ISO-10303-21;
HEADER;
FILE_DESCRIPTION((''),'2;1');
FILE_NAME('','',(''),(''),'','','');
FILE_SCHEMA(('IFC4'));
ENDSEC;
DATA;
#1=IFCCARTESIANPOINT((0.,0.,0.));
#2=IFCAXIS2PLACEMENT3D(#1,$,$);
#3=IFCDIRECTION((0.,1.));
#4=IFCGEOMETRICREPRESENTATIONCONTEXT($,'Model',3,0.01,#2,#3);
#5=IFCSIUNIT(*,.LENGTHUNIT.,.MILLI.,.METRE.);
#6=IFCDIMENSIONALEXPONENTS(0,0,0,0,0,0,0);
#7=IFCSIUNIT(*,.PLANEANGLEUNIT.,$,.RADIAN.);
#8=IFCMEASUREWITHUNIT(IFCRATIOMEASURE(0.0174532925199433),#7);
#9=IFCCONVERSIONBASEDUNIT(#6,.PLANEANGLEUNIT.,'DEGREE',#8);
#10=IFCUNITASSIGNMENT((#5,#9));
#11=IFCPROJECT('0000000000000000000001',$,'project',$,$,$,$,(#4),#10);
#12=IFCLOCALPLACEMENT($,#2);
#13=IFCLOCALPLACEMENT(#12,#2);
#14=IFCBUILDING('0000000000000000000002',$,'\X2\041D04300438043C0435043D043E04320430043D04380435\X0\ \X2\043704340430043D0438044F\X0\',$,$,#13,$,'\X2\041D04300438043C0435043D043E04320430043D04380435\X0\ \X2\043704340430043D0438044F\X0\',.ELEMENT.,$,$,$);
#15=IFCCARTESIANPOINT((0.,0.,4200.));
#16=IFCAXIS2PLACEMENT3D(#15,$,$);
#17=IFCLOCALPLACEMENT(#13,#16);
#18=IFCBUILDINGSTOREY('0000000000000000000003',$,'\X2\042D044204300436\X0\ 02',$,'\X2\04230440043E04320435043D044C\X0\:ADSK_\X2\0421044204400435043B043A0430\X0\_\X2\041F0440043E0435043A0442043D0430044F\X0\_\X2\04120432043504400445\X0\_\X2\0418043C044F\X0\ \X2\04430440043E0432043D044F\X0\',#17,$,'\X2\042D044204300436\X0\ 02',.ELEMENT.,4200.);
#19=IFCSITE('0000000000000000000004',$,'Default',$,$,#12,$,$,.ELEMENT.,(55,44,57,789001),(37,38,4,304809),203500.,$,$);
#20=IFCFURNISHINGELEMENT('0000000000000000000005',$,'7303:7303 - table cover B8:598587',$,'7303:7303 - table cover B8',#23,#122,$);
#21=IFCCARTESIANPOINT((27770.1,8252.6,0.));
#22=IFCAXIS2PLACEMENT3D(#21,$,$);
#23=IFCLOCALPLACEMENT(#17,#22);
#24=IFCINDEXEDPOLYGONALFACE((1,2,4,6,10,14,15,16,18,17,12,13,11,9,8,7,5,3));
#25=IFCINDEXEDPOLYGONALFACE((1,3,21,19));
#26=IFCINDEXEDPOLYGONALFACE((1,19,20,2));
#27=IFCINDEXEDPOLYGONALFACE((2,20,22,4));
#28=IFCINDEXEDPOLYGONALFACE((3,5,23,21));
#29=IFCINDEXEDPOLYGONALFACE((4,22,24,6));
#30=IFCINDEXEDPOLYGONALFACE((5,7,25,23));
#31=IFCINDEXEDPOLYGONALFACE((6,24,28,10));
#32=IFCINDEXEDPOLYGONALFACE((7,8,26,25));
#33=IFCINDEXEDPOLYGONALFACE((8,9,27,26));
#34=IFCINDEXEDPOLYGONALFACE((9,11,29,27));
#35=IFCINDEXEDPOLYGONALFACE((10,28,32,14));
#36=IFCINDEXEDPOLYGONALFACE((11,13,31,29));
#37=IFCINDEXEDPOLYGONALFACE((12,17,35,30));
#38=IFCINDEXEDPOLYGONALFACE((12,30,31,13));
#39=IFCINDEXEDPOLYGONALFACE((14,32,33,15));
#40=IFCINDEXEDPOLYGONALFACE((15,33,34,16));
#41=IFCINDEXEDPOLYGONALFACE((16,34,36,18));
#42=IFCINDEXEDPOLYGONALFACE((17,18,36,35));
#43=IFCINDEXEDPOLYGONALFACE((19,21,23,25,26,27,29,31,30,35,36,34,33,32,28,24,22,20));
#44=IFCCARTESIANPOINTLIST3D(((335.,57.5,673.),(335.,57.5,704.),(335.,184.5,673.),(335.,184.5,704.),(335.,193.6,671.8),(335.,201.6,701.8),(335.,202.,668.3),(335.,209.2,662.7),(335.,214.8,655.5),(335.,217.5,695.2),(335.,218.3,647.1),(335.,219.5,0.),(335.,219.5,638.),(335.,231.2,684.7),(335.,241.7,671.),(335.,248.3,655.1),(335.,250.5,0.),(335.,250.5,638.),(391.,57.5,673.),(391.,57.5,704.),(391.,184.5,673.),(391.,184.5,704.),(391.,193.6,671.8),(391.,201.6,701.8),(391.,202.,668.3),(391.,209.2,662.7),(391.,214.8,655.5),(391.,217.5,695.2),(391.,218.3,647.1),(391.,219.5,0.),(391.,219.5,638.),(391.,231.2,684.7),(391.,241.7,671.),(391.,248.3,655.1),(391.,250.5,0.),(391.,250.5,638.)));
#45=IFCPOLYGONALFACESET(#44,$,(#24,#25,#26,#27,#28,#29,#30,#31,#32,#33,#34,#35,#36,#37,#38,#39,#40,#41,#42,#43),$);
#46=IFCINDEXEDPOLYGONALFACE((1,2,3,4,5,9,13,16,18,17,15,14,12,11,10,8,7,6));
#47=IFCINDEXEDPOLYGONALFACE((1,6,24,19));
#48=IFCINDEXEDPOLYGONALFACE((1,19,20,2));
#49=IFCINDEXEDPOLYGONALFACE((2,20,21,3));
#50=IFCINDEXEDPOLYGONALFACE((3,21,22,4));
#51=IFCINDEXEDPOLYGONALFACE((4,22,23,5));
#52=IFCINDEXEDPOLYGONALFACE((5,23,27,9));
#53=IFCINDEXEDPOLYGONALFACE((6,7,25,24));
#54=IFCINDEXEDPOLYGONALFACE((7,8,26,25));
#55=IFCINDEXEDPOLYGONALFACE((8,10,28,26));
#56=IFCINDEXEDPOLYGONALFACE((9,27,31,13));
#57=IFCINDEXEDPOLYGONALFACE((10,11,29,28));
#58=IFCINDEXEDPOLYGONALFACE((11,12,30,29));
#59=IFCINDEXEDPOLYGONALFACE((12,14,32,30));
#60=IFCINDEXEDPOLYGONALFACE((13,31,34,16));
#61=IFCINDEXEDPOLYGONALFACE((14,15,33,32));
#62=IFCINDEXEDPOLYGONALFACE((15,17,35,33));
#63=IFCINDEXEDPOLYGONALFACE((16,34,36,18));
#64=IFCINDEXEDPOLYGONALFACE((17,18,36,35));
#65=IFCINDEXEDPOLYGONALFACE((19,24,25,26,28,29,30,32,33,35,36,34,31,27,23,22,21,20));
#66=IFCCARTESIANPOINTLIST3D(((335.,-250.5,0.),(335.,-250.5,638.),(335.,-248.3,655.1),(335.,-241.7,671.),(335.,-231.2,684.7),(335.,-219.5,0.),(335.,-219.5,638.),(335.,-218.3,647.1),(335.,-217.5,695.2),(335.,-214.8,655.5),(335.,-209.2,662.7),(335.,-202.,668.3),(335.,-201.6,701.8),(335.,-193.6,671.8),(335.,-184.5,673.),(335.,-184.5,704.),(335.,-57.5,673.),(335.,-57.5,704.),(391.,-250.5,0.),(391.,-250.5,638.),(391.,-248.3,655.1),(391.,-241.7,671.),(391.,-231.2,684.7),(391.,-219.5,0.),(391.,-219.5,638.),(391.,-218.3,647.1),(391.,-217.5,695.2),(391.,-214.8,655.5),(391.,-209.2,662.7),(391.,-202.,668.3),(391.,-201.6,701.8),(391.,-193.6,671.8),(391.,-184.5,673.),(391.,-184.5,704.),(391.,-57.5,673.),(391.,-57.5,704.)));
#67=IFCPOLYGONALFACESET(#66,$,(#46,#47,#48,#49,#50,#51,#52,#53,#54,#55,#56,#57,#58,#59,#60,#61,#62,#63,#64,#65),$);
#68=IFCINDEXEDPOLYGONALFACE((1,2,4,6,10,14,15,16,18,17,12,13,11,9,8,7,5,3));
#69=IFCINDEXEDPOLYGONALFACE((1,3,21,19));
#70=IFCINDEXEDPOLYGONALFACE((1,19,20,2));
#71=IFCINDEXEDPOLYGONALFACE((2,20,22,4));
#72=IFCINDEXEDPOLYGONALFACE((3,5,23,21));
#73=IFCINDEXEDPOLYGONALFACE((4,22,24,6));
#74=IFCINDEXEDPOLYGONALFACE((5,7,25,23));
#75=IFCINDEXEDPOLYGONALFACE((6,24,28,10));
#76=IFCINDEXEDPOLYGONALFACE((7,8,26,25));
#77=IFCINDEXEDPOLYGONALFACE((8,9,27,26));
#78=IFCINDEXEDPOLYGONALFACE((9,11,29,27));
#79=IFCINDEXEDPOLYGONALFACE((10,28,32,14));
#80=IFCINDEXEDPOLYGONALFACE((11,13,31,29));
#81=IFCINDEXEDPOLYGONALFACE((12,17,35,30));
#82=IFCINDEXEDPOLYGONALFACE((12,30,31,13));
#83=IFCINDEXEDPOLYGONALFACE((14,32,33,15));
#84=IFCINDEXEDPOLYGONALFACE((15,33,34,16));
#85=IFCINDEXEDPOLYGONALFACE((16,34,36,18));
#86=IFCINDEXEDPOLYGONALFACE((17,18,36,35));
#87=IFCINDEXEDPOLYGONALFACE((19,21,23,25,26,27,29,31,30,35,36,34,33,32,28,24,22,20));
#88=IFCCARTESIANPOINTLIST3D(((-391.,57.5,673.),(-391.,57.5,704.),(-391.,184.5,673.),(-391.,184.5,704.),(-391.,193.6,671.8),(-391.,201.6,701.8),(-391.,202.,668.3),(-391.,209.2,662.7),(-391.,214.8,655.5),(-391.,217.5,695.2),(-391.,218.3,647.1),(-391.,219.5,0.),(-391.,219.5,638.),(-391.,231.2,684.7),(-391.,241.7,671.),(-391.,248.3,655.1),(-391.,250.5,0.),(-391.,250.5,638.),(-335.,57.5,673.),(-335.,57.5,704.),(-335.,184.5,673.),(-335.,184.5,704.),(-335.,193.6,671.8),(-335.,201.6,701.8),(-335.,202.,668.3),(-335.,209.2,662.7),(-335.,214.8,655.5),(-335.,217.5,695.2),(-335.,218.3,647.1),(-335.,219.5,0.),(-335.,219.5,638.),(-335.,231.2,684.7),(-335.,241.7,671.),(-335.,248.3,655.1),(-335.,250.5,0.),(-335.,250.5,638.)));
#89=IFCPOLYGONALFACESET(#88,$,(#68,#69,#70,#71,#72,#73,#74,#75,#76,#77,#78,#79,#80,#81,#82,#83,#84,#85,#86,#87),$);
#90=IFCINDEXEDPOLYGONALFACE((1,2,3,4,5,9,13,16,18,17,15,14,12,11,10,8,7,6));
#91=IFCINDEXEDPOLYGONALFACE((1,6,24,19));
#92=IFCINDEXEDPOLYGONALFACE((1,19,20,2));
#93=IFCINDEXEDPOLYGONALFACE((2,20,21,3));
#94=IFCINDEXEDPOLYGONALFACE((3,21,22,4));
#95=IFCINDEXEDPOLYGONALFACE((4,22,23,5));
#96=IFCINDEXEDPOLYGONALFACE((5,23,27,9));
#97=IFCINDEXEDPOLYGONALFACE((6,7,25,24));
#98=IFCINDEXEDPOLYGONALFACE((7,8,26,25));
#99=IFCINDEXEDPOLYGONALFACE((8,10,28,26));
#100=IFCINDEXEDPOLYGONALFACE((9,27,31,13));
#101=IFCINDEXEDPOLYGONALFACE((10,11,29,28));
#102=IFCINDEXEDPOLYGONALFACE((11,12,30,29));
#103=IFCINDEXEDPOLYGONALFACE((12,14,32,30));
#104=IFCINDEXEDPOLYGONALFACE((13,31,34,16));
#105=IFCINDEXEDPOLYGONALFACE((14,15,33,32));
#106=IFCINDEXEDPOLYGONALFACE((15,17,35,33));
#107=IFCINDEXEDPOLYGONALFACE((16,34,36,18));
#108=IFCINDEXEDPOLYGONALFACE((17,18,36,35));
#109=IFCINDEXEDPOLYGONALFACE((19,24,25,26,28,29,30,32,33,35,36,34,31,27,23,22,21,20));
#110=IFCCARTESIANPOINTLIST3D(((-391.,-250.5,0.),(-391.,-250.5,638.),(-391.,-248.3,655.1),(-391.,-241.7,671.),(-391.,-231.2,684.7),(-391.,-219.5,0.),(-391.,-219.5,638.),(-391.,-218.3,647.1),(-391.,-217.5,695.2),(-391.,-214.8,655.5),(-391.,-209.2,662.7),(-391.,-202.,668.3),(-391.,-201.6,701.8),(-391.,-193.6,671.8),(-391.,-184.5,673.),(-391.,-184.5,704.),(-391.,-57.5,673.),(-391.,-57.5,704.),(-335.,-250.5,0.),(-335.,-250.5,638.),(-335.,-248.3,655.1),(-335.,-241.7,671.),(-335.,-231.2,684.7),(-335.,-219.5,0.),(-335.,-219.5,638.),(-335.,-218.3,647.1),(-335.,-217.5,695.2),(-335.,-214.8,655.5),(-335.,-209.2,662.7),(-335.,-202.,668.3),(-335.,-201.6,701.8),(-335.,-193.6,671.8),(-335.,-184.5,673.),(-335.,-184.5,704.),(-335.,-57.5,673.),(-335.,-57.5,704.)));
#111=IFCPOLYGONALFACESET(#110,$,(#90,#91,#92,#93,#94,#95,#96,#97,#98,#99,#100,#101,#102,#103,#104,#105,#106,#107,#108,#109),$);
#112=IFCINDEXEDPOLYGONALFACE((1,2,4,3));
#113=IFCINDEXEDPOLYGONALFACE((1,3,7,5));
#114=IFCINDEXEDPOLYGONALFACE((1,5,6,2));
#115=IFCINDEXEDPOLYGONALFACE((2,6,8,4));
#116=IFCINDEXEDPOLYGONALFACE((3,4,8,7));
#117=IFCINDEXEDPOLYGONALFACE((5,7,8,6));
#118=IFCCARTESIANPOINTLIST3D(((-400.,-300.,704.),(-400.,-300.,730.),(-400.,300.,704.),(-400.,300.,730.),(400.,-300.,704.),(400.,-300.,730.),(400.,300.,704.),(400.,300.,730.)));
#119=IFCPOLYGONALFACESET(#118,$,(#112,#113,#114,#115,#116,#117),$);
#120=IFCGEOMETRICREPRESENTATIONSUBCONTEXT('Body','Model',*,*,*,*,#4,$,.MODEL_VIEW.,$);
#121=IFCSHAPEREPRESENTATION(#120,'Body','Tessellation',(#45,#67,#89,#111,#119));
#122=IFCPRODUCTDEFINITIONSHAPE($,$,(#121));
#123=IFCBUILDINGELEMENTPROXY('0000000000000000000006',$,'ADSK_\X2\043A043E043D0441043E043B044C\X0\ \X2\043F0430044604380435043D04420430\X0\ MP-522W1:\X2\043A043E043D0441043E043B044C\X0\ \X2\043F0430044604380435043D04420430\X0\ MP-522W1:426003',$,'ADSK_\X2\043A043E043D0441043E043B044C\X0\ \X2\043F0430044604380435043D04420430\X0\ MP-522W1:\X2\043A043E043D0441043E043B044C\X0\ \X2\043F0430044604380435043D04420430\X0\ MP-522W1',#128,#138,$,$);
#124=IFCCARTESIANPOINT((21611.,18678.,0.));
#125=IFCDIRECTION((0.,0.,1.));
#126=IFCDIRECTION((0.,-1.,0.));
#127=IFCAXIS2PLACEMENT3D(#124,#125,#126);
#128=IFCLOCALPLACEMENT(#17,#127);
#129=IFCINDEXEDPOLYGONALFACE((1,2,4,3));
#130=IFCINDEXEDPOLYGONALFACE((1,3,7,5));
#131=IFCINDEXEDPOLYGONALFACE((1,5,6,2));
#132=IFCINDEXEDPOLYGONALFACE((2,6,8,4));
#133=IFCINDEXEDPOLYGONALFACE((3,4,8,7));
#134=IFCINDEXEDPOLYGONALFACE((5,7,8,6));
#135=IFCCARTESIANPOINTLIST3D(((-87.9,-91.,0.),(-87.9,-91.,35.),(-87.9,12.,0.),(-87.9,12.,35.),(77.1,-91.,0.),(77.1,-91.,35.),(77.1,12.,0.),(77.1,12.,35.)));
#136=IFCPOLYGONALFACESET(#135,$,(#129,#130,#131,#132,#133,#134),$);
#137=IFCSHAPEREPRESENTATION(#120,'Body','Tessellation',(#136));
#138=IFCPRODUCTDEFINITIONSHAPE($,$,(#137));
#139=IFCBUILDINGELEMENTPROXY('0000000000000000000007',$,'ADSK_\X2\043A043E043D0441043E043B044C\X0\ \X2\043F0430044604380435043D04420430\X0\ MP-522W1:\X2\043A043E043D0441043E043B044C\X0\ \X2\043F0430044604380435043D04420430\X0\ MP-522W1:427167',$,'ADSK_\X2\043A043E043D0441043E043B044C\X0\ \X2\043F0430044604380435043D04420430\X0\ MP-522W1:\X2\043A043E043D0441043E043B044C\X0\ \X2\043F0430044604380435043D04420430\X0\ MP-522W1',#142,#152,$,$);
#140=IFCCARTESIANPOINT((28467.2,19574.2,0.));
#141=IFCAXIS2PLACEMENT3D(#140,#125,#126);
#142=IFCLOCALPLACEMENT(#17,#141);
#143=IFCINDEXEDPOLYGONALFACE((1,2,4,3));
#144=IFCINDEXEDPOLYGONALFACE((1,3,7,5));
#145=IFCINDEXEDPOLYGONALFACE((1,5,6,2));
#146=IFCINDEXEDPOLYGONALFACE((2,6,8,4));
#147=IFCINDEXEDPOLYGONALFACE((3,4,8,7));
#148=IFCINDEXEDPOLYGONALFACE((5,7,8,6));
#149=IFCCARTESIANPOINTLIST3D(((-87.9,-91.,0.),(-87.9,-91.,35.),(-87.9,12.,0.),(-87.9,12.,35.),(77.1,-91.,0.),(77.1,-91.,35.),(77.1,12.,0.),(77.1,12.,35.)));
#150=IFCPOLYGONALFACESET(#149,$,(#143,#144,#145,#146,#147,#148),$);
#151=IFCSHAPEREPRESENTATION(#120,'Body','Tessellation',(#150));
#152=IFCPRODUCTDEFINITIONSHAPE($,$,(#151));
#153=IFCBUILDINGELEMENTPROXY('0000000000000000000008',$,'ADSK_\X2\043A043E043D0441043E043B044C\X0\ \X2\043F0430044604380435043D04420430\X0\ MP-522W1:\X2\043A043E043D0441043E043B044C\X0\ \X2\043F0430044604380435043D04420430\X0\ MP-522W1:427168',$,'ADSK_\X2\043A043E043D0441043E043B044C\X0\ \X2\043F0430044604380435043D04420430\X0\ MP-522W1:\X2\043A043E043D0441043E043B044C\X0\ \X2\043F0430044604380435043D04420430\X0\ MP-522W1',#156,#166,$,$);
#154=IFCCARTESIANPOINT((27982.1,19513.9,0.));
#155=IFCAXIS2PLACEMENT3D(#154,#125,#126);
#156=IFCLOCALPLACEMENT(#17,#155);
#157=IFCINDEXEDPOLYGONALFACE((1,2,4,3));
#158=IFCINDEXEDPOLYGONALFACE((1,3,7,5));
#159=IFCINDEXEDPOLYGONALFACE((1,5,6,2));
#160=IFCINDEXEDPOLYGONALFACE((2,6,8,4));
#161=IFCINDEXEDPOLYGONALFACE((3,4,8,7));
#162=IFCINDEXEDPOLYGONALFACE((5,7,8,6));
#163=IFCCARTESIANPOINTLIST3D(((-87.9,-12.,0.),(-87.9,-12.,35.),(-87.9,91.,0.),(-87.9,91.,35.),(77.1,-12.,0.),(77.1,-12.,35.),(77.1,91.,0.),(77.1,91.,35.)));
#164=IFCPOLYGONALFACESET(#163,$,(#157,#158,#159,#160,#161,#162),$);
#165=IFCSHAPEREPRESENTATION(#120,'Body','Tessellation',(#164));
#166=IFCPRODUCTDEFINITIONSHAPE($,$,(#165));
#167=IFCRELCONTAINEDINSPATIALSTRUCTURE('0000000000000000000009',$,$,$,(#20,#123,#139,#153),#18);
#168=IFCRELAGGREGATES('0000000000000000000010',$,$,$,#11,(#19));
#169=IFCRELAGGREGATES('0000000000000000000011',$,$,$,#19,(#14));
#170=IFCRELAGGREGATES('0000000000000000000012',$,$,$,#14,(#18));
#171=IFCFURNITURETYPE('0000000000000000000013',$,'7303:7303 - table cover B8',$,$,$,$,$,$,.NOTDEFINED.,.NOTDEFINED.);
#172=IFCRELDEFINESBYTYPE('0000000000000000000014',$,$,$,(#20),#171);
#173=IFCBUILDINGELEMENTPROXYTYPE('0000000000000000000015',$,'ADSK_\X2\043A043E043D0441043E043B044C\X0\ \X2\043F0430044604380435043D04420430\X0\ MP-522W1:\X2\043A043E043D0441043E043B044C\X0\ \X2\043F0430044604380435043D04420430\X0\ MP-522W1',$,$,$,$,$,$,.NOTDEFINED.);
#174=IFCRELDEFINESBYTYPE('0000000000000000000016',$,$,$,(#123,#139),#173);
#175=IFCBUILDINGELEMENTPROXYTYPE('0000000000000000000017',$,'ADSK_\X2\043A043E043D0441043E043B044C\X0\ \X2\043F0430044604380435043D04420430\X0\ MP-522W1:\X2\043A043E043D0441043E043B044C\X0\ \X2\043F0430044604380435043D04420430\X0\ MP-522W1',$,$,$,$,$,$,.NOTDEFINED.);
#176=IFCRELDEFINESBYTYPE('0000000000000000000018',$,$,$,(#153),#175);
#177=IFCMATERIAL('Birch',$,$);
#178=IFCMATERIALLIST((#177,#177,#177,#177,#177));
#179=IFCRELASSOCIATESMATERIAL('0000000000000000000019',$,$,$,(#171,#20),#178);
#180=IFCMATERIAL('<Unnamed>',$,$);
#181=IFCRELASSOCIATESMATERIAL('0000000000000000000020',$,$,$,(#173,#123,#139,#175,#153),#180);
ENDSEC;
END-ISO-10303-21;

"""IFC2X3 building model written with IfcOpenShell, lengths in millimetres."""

from ifc_helpers import new_model, entity, si_unit, converted_unit, direction, frame, frame_2d, origin, origin_2d_with_axis, place, context, subcontext, project, spatial, polyline, circle_curve, parameter, trimmed, segment, composite_curve, rectangle, outline, extrude, source, transform, mapped, material, material_list, type_object, type_shapes, element, save


model = new_model("IFC2X3")

# Units and contexts
model_context = context("Model", 3, precision=0.01, world=origin(), true_north=direction((0.0, 1.0)))
body_context = subcontext(model_context, "Body", "Model", "MODEL_VIEW")
ifc_project = project(units=[si_unit("LENGTHUNIT", "METRE", prefix="MILLI"), converted_unit("PLANEANGLEUNIT", "DEGREE", entity("IfcRatioMeasure", 0.0174532925199433), si_unit("PLANEANGLEUNIT", "RADIAN"), dimensions=[0, 0, 0, 0, 0, 0, 0])], contexts=[model_context])

# Site, building, storey
site_placement = place(None, origin())
site = spatial("IfcSite", under=ifc_project, at=site_placement, Name="Default", CompositionType="ELEMENT", RefLatitude=(55, 44, 57, 789001), RefLongitude=(37, 38, 4, 304809), RefElevation=203500.0)
building_placement = place(site_placement, origin())
building = spatial("IfcBuilding", under=site, at=building_placement, Name="Наименование здания", LongName="Наименование здания", CompositionType="ELEMENT")
storey_placement = place(building_placement, frame((0.0, 0.0, 4200.0)))
storey = spatial("IfcBuildingStorey", under=building, at=storey_placement, Name="Этаж 02", ObjectType="Уровень:ADSK_Стрелка_Проектная_Вверх_Имя уровня", LongName="Этаж 02", CompositionType="ELEMENT", Elevation=4200.0)

# Furnishing element
ifc_material_1 = material(Name="Birch")
ifc_material_list_1 = material_list([ifc_material_1, ifc_material_1, ifc_material_1, ifc_material_1, ifc_material_1])
furniture_type_1 = type_object("IfcFurnitureType", Name="7303:7303 - table cover B8", material=ifc_material_list_1)
shared_shape_1 = source(origin(), body_context, "Body", "SweptSolid", [
    extrude(outline(composite_curve([segment(polyline([(-200.2, -120.5), (-169.2, -120.5)]), True, "CONTINUOUS"), segment(polyline([(-169.2, -120.5), (-169.2, 6.5)]), True, "CONTINUOUS"), segment(trimmed(circle_curve(frame_2d((-134.2, 6.5), x_axis=(0.0, -1.0)), 35.0), [parameter(180.0)], [parameter(270.0)], True, "PARAMETER"), False, "CONTINUOUS"), segment(polyline([(-134.2, 41.5), (503.8, 41.5)]), True, "CONTINUOUS"), segment(polyline([(503.8, 41.5), (503.8, 72.5)]), True, "CONTINUOUS"), segment(polyline([(503.8, 72.5), (-134.2, 72.5)]), True, "CONTINUOUS"), segment(trimmed(circle_curve(frame_2d((-134.2, 6.5), x_axis=(0.0, -1.0)), 66.0), [parameter(180.0)], [parameter(270.0)], True, "PARAMETER"), True, "CONTINUOUS"), segment(polyline([(-200.2, 6.5), (-200.2, -120.5)]), True, "CONTINUOUS")], self_intersect=False)), frame((335.0, 178.0, 503.8), z_axis=(1.0, 0.0, 0.0), x_axis=(0.0, 0.0, -1.0)), (0.0, 0.0, 1.0), 56.0),
    extrude(outline(composite_curve([segment(polyline([(-120.5, -200.2), (6.5, -200.2)]), True, "CONTINUOUS"), segment(trimmed(circle_curve(frame_2d((6.5, -134.2), x_axis=(-1.0, 0.0)), 66.0), [parameter(90.0)], [parameter(180.0)], True, "PARAMETER"), True, "CONTINUOUS"), segment(polyline([(72.5, -134.2), (72.5, 503.8)]), True, "CONTINUOUS"), segment(polyline([(72.5, 503.8), (41.5, 503.8)]), True, "CONTINUOUS"), segment(polyline([(41.5, 503.8), (41.5, -134.2)]), True, "CONTINUOUS"), segment(trimmed(circle_curve(frame_2d((6.5, -134.2), x_axis=(-1.0, 0.0)), 35.0), [parameter(90.0)], [parameter(180.0)], True, "PARAMETER"), False, "CONTINUOUS"), segment(polyline([(6.5, -169.2), (-120.5, -169.2)]), True, "CONTINUOUS"), segment(polyline([(-120.5, -169.2), (-120.5, -200.2)]), True, "CONTINUOUS")], self_intersect=False)), frame((335.0, -178.0, 503.8), z_axis=(1.0, 0.0, 0.0), x_axis=(0.0, -1.0, 0.0)), (0.0, 0.0, 1.0), 56.0),
    extrude(outline(composite_curve([segment(polyline([(-200.2, -120.5), (-169.2, -120.5)]), True, "CONTINUOUS"), segment(polyline([(-169.2, -120.5), (-169.2, 6.5)]), True, "CONTINUOUS"), segment(trimmed(circle_curve(frame_2d((-134.2, 6.5), x_axis=(0.0, -1.0)), 35.0), [parameter(180.0)], [parameter(270.0)], True, "PARAMETER"), False, "CONTINUOUS"), segment(polyline([(-134.2, 41.5), (503.8, 41.5)]), True, "CONTINUOUS"), segment(polyline([(503.8, 41.5), (503.8, 72.5)]), True, "CONTINUOUS"), segment(polyline([(503.8, 72.5), (-134.2, 72.5)]), True, "CONTINUOUS"), segment(trimmed(circle_curve(frame_2d((-134.2, 6.5), x_axis=(0.0, -1.0)), 66.0), [parameter(180.0)], [parameter(270.0)], True, "PARAMETER"), True, "CONTINUOUS"), segment(polyline([(-200.2, 6.5), (-200.2, -120.5)]), True, "CONTINUOUS")], self_intersect=False)), frame((-391.0, 178.0, 503.8), z_axis=(1.0, 0.0, 0.0), x_axis=(0.0, 0.0, -1.0)), (0.0, 0.0, 1.0), 56.0),
    extrude(outline(composite_curve([segment(polyline([(-120.5, -200.2), (6.5, -200.2)]), True, "CONTINUOUS"), segment(trimmed(circle_curve(frame_2d((6.5, -134.2), x_axis=(-1.0, 0.0)), 66.0), [parameter(90.0)], [parameter(180.0)], True, "PARAMETER"), True, "CONTINUOUS"), segment(polyline([(72.5, -134.2), (72.5, 503.8)]), True, "CONTINUOUS"), segment(polyline([(72.5, 503.8), (41.5, 503.8)]), True, "CONTINUOUS"), segment(polyline([(41.5, 503.8), (41.5, -134.2)]), True, "CONTINUOUS"), segment(trimmed(circle_curve(frame_2d((6.5, -134.2), x_axis=(-1.0, 0.0)), 35.0), [parameter(90.0)], [parameter(180.0)], True, "PARAMETER"), False, "CONTINUOUS"), segment(polyline([(6.5, -169.2), (-120.5, -169.2)]), True, "CONTINUOUS"), segment(polyline([(-120.5, -169.2), (-120.5, -200.2)]), True, "CONTINUOUS")], self_intersect=False)), frame((-391.0, -178.0, 503.8), z_axis=(1.0, 0.0, 0.0), x_axis=(0.0, -1.0, 0.0)), (0.0, 0.0, 1.0), 56.0),
    extrude(rectangle(XDim=800.0, YDim=600.0, at=origin_2d_with_axis()), frame((0.0, 0.0, 704.0), z_axis=(0.0, 0.0, 1.0), x_axis=(-1.0, 0.0, 0.0)), (0.0, 0.0, 1.0), 26.0),
])
type_shapes(furniture_type_1, [shared_shape_1])
furnishing_1_placement = place(storey_placement, frame((27770.1, 8252.6, 0.0)))
element("IfcFurnishingElement", 1, at=furnishing_1_placement, inside=storey, type_object=furniture_type_1, material=ifc_material_list_1, Name="7303:7303 - table cover B8:598587", ObjectType="7303:7303 - table cover B8", context=body_context, shape_type="MappedRepresentation", body=[
    mapped(shared_shape_1, transform((0.0, 0.0, 0.0), scale=1.0)),
])

# Building element proxies
ifc_material_2 = material(Name="<Unnamed>")
building_element_proxy_type_1 = type_object("IfcBuildingElementProxyType", Name="ADSK_консоль пациента MP-522W1:консоль пациента MP-522W1", PredefinedType="NOTDEFINED", material=ifc_material_2)
shared_shape_2 = source(origin(), body_context, "Body", "SweptSolid", [
    extrude(rectangle(XDim=165.0, YDim=103.0, at=origin_2d_with_axis()), frame((-5.4, -39.5, 0.0), z_axis=(0.0, 0.0, 1.0), x_axis=(-1.0, 0.0, 0.0)), (0.0, 0.0, 1.0), 35.0),
])
type_shapes(building_element_proxy_type_1, [shared_shape_2])
for number, where, z_axis, x_axis, name in (
    (2, (21611.0, 18678.0, 0.0), (0.0, 0.0, 1.0), (0.0, -1.0, 0.0), "ADSK_консоль пациента MP-522W1:консоль пациента MP-522W1:426003"),
    (3, (28467.2, 19574.2, 0.0), (0.0, 0.0, 1.0), (0.0, -1.0, 0.0), "ADSK_консоль пациента MP-522W1:консоль пациента MP-522W1:427167"),
):
    element("IfcBuildingElementProxy", number, at=place(storey_placement, frame(where, z_axis=z_axis, x_axis=x_axis)), inside=storey, type_object=building_element_proxy_type_1, material=ifc_material_2, Name=name, ObjectType="ADSK_консоль пациента MP-522W1:консоль пациента MP-522W1", context=body_context, shape_type="MappedRepresentation", body=[
        mapped(shared_shape_2, transform((0.0, 0.0, 0.0), scale=1.0)),
    ])
building_element_proxy_type_2 = type_object("IfcBuildingElementProxyType", Name="ADSK_консоль пациента MP-522W1:консоль пациента MP-522W1", PredefinedType="NOTDEFINED", material=ifc_material_2)
shared_shape_3 = source(origin(), body_context, "Body", "SweptSolid", [
    extrude(rectangle(XDim=103.0, YDim=165.0, at=origin_2d_with_axis()), frame((-5.4, 39.5, 0.0), z_axis=(0.0, 0.0, 1.0), x_axis=(0.0, 1.0, 0.0)), (0.0, 0.0, 1.0), 35.0),
])
type_shapes(building_element_proxy_type_2, [shared_shape_3])
proxy_1_placement = place(storey_placement, frame((27982.1, 19513.9, 0.0), z_axis=(0.0, 0.0, 1.0), x_axis=(0.0, -1.0, 0.0)))
element("IfcBuildingElementProxy", 4, at=proxy_1_placement, inside=storey, type_object=building_element_proxy_type_2, material=ifc_material_2, Name="ADSK_консоль пациента MP-522W1:консоль пациента MP-522W1:427168", ObjectType="ADSK_консоль пациента MP-522W1:консоль пациента MP-522W1", context=body_context, shape_type="MappedRepresentation", body=[
    mapped(shared_shape_3, transform((0.0, 0.0, 0.0), scale=1.0)),
])

save(model, "model.ifc")
